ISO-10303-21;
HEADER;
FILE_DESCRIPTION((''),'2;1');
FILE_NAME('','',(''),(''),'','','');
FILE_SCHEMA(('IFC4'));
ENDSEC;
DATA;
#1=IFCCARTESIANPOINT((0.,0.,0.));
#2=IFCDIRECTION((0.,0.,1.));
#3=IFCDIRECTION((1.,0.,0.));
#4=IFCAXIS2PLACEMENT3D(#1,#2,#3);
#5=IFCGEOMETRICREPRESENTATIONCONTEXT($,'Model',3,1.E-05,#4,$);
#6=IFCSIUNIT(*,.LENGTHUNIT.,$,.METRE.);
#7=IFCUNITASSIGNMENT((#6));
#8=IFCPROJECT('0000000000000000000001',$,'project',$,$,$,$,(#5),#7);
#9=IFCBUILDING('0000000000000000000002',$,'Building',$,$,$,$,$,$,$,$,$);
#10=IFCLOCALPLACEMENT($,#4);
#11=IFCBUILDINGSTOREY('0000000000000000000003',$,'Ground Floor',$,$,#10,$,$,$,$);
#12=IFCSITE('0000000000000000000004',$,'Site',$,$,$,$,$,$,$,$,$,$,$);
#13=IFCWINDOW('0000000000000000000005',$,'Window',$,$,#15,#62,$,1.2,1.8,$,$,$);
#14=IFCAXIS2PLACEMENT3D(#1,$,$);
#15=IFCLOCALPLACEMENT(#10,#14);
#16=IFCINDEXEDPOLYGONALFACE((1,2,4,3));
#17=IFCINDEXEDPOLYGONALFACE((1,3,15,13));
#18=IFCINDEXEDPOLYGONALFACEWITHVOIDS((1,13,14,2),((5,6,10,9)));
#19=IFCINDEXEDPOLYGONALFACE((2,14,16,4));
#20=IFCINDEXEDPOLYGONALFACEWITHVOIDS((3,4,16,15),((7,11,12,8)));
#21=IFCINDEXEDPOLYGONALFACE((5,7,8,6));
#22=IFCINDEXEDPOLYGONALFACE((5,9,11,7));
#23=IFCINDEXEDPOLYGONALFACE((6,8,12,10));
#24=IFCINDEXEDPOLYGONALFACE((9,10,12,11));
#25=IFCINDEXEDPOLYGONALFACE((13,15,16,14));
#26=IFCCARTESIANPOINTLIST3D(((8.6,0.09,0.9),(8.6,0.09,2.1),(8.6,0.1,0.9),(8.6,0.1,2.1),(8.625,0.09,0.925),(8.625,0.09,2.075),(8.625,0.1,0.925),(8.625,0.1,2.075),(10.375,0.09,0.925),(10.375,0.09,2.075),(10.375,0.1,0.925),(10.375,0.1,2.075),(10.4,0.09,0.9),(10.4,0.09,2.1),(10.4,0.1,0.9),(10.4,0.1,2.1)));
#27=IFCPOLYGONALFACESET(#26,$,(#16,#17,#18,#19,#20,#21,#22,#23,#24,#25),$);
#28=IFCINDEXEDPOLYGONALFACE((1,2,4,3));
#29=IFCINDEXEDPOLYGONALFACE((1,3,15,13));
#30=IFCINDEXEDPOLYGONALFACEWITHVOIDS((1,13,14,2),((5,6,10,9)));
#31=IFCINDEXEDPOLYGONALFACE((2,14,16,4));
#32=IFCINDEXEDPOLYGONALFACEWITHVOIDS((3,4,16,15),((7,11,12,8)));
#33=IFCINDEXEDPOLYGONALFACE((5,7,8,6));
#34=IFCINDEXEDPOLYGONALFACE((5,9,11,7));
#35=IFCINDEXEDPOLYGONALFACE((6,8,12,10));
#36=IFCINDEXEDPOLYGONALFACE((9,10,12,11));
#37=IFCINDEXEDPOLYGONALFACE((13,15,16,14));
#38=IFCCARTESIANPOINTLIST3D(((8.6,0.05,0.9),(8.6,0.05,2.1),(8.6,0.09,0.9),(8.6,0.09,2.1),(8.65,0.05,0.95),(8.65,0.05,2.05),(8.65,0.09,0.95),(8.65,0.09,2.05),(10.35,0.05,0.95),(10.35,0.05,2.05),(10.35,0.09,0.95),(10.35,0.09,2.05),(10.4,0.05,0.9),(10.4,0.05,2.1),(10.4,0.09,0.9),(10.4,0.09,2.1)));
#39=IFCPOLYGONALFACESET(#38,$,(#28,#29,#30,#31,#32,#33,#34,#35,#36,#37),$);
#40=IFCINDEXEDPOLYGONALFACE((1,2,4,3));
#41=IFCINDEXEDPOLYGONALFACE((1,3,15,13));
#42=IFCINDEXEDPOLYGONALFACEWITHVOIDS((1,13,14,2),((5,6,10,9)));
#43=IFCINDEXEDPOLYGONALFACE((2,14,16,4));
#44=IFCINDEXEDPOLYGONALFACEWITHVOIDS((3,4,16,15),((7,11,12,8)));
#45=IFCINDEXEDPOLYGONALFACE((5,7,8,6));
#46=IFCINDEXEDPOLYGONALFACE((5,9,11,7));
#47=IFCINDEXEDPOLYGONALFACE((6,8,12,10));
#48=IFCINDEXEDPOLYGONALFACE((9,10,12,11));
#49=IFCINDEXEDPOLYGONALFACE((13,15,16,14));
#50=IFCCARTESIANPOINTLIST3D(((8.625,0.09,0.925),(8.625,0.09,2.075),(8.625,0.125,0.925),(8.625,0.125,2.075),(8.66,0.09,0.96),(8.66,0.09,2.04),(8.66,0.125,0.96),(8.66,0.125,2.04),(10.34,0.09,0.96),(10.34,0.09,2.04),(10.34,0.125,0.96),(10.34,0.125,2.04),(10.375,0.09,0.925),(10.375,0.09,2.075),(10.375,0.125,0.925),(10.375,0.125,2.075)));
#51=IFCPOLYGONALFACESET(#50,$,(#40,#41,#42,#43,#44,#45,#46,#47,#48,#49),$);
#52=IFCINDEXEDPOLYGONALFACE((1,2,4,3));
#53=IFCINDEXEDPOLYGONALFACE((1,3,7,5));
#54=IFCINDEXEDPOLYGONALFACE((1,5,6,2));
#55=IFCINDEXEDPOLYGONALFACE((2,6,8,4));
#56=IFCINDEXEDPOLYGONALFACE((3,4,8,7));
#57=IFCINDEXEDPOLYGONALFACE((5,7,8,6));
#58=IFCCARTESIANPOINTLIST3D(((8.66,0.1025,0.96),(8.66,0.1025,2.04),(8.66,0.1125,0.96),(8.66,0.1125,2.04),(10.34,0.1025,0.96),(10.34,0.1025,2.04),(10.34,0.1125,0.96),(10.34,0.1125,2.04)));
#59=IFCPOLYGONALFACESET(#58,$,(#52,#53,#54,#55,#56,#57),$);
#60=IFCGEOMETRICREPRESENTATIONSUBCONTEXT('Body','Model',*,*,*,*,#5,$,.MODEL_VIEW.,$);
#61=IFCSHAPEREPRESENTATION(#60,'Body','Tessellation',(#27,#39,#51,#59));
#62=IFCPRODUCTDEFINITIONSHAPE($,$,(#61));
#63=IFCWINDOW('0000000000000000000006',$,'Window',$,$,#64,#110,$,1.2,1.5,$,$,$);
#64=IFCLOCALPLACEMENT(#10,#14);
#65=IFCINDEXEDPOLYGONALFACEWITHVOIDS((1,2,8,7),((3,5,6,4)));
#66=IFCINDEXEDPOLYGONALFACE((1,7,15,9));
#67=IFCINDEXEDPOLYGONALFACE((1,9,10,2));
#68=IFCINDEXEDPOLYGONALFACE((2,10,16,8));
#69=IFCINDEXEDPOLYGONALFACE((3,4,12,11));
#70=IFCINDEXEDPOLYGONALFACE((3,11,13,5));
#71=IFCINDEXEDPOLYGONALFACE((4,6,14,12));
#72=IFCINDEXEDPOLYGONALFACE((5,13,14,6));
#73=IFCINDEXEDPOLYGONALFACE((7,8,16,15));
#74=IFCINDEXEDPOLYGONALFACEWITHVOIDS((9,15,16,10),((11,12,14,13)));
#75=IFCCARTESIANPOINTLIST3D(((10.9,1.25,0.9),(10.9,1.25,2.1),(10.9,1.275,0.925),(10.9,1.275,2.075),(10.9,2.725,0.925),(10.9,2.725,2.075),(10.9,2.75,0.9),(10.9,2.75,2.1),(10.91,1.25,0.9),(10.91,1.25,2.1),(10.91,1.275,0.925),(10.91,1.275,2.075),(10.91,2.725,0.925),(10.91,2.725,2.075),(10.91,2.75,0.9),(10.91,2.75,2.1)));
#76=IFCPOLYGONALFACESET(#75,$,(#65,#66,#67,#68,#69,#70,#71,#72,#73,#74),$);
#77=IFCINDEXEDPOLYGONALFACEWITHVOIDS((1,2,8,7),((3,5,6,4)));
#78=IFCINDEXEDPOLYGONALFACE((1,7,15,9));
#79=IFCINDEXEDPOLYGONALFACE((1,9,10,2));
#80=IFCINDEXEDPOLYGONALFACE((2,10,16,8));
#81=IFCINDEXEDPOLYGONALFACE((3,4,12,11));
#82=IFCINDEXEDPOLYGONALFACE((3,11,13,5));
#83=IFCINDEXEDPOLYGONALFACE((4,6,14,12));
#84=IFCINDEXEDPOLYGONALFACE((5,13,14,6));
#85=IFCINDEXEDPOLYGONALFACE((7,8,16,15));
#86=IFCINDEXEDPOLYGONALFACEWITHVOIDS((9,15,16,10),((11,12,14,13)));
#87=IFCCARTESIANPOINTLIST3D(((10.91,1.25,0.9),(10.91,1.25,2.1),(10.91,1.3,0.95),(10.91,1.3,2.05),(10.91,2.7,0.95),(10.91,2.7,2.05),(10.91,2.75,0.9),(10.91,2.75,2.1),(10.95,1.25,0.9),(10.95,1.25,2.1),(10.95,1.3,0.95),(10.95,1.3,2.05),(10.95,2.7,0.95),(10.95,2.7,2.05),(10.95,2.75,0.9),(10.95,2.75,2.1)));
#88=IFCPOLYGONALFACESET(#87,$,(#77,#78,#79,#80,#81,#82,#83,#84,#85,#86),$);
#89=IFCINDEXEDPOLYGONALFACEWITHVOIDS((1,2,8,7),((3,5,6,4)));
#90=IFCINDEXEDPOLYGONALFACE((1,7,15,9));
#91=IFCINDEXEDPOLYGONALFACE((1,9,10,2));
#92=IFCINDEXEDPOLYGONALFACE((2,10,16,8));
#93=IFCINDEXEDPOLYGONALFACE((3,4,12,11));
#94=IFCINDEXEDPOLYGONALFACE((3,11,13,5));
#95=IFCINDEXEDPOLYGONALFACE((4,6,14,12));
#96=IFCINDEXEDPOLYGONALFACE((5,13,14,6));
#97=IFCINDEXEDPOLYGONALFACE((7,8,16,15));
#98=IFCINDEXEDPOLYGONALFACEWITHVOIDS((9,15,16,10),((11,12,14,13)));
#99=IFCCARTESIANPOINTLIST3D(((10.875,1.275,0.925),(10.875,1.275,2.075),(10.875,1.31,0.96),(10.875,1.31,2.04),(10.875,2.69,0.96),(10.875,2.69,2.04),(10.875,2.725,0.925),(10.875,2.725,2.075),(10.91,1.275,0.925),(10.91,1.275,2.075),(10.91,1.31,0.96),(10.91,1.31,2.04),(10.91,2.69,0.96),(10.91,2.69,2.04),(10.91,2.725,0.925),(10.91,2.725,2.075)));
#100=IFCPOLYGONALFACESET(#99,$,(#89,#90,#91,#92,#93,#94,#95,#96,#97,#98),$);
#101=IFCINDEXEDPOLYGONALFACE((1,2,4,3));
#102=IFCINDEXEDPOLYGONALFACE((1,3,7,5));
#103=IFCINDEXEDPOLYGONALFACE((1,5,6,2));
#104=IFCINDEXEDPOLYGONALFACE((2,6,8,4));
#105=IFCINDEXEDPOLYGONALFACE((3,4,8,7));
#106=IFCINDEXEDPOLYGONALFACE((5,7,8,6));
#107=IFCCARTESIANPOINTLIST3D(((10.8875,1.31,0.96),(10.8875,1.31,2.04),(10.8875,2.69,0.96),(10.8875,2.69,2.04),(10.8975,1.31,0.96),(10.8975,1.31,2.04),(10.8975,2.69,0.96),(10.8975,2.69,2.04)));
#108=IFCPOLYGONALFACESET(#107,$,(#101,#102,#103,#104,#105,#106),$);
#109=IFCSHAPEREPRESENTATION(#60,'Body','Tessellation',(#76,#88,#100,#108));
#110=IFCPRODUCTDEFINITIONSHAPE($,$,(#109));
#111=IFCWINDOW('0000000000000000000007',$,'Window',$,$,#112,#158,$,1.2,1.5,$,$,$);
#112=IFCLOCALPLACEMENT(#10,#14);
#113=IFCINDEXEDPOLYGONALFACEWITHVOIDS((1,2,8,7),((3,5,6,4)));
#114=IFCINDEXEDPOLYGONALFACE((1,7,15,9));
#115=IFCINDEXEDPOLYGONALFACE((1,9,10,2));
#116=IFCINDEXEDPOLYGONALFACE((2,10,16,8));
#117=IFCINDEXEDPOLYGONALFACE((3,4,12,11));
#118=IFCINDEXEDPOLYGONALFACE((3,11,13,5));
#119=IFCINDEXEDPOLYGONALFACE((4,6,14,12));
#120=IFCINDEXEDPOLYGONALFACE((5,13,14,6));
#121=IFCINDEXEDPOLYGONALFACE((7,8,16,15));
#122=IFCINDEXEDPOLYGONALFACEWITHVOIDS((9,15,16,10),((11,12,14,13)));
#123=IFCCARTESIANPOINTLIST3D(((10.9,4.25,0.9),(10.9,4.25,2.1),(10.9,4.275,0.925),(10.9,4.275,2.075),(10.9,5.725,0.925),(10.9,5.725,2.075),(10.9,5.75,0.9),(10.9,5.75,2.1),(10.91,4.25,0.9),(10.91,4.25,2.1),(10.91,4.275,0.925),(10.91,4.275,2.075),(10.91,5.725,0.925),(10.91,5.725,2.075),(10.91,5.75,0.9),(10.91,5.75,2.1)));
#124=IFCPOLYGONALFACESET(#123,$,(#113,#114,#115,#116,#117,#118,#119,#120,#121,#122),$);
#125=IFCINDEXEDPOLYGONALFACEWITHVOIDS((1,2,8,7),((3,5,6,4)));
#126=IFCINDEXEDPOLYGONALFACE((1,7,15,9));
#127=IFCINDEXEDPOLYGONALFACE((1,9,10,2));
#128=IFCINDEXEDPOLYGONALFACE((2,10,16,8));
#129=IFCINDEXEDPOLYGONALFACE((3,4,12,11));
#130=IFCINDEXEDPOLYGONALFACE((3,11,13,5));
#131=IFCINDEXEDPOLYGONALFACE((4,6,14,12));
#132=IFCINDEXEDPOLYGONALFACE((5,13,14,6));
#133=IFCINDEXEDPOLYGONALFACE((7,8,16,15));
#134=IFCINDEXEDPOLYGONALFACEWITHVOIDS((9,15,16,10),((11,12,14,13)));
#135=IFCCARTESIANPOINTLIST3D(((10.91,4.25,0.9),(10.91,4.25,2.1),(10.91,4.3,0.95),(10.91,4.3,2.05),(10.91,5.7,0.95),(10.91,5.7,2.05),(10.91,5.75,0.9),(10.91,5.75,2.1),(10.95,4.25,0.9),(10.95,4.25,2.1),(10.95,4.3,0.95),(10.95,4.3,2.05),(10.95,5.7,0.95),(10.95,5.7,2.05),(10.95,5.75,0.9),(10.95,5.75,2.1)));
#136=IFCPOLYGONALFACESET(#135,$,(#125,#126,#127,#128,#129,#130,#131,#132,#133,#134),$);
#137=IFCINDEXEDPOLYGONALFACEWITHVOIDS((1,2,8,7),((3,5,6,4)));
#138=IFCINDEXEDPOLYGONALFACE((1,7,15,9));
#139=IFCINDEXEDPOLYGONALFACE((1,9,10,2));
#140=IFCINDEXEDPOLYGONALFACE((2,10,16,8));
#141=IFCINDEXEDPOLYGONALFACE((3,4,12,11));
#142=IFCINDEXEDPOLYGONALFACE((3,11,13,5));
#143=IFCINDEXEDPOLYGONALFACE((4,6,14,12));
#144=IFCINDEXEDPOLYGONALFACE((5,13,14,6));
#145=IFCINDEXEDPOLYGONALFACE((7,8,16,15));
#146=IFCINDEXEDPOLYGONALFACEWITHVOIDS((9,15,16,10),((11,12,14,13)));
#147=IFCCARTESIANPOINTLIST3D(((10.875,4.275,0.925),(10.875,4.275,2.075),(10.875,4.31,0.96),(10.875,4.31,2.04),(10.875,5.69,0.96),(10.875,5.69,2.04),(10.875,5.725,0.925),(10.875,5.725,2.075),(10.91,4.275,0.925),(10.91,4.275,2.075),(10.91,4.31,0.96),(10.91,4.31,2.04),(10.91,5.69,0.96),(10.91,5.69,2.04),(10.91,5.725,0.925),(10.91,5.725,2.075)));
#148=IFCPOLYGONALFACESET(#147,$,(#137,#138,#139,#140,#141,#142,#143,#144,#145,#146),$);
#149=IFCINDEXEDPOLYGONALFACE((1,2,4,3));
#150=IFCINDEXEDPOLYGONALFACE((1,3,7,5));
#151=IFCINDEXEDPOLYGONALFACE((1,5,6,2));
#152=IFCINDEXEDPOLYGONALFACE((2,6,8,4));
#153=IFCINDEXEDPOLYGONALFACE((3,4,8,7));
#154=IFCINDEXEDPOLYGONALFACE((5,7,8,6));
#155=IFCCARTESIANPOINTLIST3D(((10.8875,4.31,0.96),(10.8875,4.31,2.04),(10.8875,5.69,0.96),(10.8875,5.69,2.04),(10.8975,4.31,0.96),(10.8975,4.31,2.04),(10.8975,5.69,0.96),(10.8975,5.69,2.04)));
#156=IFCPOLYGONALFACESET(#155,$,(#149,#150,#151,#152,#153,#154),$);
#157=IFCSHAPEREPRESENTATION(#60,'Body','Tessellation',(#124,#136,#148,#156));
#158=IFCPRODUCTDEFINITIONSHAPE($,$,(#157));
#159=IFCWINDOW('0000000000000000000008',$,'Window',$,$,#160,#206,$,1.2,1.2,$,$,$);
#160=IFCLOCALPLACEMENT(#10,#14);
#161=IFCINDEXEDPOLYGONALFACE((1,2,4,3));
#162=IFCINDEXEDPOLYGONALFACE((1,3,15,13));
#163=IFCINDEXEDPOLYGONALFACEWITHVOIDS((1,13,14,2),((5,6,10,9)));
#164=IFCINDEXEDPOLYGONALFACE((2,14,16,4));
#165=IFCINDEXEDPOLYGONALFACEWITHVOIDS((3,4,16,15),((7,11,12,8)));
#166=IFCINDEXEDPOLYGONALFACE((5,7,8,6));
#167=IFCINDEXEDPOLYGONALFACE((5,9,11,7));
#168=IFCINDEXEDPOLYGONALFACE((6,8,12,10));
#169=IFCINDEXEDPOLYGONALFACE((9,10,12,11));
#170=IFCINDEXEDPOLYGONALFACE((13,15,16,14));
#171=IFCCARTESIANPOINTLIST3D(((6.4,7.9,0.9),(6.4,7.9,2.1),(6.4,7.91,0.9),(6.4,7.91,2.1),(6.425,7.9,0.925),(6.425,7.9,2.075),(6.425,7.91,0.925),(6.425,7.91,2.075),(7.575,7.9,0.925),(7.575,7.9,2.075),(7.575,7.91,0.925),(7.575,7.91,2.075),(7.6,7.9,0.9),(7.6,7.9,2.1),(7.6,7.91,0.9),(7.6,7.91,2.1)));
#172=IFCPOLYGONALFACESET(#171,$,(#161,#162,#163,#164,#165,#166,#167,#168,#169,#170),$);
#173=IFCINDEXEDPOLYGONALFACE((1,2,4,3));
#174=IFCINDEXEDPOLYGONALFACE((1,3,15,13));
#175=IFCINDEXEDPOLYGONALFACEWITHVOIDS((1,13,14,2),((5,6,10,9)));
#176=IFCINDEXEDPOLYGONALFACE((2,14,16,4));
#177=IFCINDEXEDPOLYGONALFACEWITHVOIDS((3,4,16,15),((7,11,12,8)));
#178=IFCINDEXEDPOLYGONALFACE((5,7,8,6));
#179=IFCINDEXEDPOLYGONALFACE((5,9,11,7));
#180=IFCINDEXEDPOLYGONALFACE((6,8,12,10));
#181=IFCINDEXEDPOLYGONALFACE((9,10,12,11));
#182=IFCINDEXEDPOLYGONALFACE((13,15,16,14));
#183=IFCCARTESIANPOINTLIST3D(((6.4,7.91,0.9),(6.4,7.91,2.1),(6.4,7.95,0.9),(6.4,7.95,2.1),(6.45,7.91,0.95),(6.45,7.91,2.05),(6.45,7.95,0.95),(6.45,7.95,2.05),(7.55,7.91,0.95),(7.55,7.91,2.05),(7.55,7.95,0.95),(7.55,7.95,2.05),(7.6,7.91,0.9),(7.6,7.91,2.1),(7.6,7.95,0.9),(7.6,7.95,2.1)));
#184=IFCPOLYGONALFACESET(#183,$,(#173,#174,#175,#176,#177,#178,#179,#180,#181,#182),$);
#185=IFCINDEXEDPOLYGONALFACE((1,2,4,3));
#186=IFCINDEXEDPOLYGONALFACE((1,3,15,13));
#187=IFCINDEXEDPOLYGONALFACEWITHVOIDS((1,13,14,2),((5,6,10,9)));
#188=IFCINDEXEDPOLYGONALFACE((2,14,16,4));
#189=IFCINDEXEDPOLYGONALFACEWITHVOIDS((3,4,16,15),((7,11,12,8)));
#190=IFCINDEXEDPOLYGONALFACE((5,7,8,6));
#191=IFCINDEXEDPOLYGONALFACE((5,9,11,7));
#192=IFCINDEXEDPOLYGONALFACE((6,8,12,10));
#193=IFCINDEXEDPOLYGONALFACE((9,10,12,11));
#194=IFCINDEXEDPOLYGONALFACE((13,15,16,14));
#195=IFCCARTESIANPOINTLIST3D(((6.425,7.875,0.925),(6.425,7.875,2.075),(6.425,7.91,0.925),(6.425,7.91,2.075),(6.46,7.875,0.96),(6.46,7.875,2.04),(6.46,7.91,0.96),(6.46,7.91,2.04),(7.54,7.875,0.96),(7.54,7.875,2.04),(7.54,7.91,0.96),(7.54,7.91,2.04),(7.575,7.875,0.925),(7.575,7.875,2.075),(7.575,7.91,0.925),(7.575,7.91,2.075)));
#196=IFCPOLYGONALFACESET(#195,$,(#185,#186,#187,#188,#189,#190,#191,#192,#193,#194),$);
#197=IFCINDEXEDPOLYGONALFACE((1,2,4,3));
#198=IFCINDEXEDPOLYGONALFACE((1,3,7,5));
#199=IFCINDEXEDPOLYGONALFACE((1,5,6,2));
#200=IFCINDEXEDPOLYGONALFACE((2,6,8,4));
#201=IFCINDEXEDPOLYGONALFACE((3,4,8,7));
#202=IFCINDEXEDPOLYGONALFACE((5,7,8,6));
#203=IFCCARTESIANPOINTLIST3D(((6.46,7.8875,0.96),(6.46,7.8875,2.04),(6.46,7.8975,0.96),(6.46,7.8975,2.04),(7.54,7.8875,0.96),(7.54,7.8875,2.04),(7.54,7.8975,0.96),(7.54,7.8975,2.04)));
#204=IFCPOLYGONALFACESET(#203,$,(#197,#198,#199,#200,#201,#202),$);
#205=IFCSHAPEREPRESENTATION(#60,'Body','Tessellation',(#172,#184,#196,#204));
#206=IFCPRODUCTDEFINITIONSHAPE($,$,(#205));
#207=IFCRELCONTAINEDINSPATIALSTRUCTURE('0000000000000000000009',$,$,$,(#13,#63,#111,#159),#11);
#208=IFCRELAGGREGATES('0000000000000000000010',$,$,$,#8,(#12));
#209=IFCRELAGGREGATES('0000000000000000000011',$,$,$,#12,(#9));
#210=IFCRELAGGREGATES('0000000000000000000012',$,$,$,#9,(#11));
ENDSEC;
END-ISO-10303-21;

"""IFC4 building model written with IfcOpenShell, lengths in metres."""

from ifc_helpers import new_model, si_unit, frame, origin_with_axes, place, context, subcontext, project, spatial, line, indexed_curve, outline, extrude, element, save


model = new_model("IFC4")

# Units and contexts
model_context = context("Model", 3, precision=1e-05, world=origin_with_axes())
body_context = subcontext(model_context, "Body", "Model", "MODEL_VIEW")
ifc_project = project(units=[si_unit("LENGTHUNIT", "METRE")], contexts=[model_context])

# Site, building, storey
site = spatial("IfcSite", under=ifc_project, Name="Site")
building = spatial("IfcBuilding", under=site, Name="Building")
storey_placement = place(None, origin_with_axes())
storey = spatial("IfcBuildingStorey", under=building, at=storey_placement, Name="Ground Floor")

# Windows
window_1_placement = place(storey_placement, frame((8.6, 0.0, 0.9), z_axis=(0.0, 0.0, 1.0), x_axis=(1.0, 0.0, 0.0)))
element("IfcWindow", 1, at=window_1_placement, inside=storey, Name="Window", OverallHeight=1.2, OverallWidth=1.8, context=body_context, shape_type="SweptSolid", body=[
    extrude(outline(indexed_curve([(0.0, 0.0), (1.8, 0.0), (1.8, 1.2), (0.0, 1.2)], segments=[line(1, 2, 3, 4, 1)]), holes=[indexed_curve([(0.025, 0.025), (1.775, 0.025), (1.775, 1.175), (0.025, 1.175)], segments=[line(1, 2, 3, 4, 1)])]), frame((0.0, 0.09, 0.0), z_axis=(0.0, -1.0, 0.0), x_axis=(1.0, 0.0, 0.0)), (0.0, 0.0, -1.0), 0.01),
    extrude(outline(indexed_curve([(0.0, 0.0), (1.8, 0.0), (1.8, 1.2), (0.0, 1.2)], segments=[line(1, 2, 3, 4, 1)]), holes=[indexed_curve([(0.05, 0.05), (1.75, 0.05), (1.75, 1.15), (0.05, 1.15)], segments=[line(1, 2, 3, 4, 1)])]), frame((0.0, 0.05, 0.0), z_axis=(0.0, -1.0, 0.0), x_axis=(1.0, 0.0, 0.0)), (0.0, 0.0, -1.0), 0.04),
    extrude(outline(indexed_curve([(0.0, 0.0), (1.75, 0.0), (1.75, 1.15), (0.0, 1.15)], segments=[line(1, 2, 3, 4, 1)]), holes=[indexed_curve([(0.035, 0.035), (1.715, 0.035), (1.715, 1.115), (0.035, 1.115)], segments=[line(1, 2, 3, 4, 1)])]), frame((0.025, 0.09, 0.025), z_axis=(0.0, -1.0, 0.0), x_axis=(1.0, 0.0, 0.0)), (0.0, 0.0, -1.0), 0.035),
    extrude(outline(indexed_curve([(0.035, 0.035), (1.715, 0.035), (1.715, 1.115), (0.035, 1.115)], segments=[line(1, 2, 3, 4, 1)])), frame((0.025, 0.1025, 0.025), z_axis=(0.0, -1.0, 0.0), x_axis=(1.0, 0.0, 0.0)), (0.0, 0.0, -1.0), 0.01),
])
for number, where, z_axis, x_axis, name in (
    (2, (11.0, 1.25, 0.9), (0.0, 0.0, 1.0), (0.0, 1.0, 0.0), "Window"),
    (3, (11.0, 4.25, 0.9), (0.0, 0.0, 1.0), (0.0, 1.0, 0.0), "Window"),
):
    element("IfcWindow", number, at=place(storey_placement, frame(where, z_axis=z_axis, x_axis=x_axis)), inside=storey, Name=name, OverallHeight=1.2, OverallWidth=1.5, context=body_context, shape_type="SweptSolid", body=[
        extrude(outline(indexed_curve([(0.0, 0.0), (1.5, 0.0), (1.5, 1.2), (0.0, 1.2)], segments=[line(1, 2, 3, 4, 1)]), holes=[indexed_curve([(0.025, 0.025), (1.475, 0.025), (1.475, 1.175), (0.025, 1.175)], segments=[line(1, 2, 3, 4, 1)])]), frame((0.0, 0.09, 0.0), z_axis=(0.0, -1.0, 0.0), x_axis=(1.0, 0.0, 0.0)), (0.0, 0.0, -1.0), 0.01),
        extrude(outline(indexed_curve([(0.0, 0.0), (1.5, 0.0), (1.5, 1.2), (0.0, 1.2)], segments=[line(1, 2, 3, 4, 1)]), holes=[indexed_curve([(0.05, 0.05), (1.45, 0.05), (1.45, 1.15), (0.05, 1.15)], segments=[line(1, 2, 3, 4, 1)])]), frame((0.0, 0.05, 0.0), z_axis=(0.0, -1.0, 0.0), x_axis=(1.0, 0.0, 0.0)), (0.0, 0.0, -1.0), 0.04),
        extrude(outline(indexed_curve([(0.0, 0.0), (1.45, 0.0), (1.45, 1.15), (0.0, 1.15)], segments=[line(1, 2, 3, 4, 1)]), holes=[indexed_curve([(0.035, 0.035), (1.415, 0.035), (1.415, 1.115), (0.035, 1.115)], segments=[line(1, 2, 3, 4, 1)])]), frame((0.025, 0.09, 0.025), z_axis=(0.0, -1.0, 0.0), x_axis=(1.0, 0.0, 0.0)), (0.0, 0.0, -1.0), 0.035),
        extrude(outline(indexed_curve([(0.035, 0.035), (1.415, 0.035), (1.415, 1.115), (0.035, 1.115)], segments=[line(1, 2, 3, 4, 1)])), frame((0.025, 0.1025, 0.025), z_axis=(0.0, -1.0, 0.0), x_axis=(1.0, 0.0, 0.0)), (0.0, 0.0, -1.0), 0.01),
    ])
window_2_placement = place(storey_placement, frame((7.6, 8.0, 0.9), z_axis=(0.0, 0.0, 1.0), x_axis=(-1.0, 0.0, 0.0)))
element("IfcWindow", 4, at=window_2_placement, inside=storey, Name="Window", OverallHeight=1.2, OverallWidth=1.2, context=body_context, shape_type="SweptSolid", body=[
    extrude(outline(indexed_curve([(0.0, 0.0), (1.2, 0.0), (1.2, 1.2), (0.0, 1.2)], segments=[line(1, 2, 3, 4, 1)]), holes=[indexed_curve([(0.025, 0.025), (1.175, 0.025), (1.175, 1.175), (0.025, 1.175)], segments=[line(1, 2, 3, 4, 1)])]), frame((0.0, 0.09, 0.0), z_axis=(0.0, -1.0, 0.0), x_axis=(1.0, 0.0, 0.0)), (0.0, 0.0, -1.0), 0.01),
    extrude(outline(indexed_curve([(0.0, 0.0), (1.2, 0.0), (1.2, 1.2), (0.0, 1.2)], segments=[line(1, 2, 3, 4, 1)]), holes=[indexed_curve([(0.05, 0.05), (1.15, 0.05), (1.15, 1.15), (0.05, 1.15)], segments=[line(1, 2, 3, 4, 1)])]), frame((0.0, 0.05, 0.0), z_axis=(0.0, -1.0, 0.0), x_axis=(1.0, 0.0, 0.0)), (0.0, 0.0, -1.0), 0.04),
    extrude(outline(indexed_curve([(0.0, 0.0), (1.15, 0.0), (1.15, 1.15), (0.0, 1.15)], segments=[line(1, 2, 3, 4, 1)]), holes=[indexed_curve([(0.035, 0.035), (1.115, 0.035), (1.115, 1.115), (0.035, 1.115)], segments=[line(1, 2, 3, 4, 1)])]), frame((0.025, 0.09, 0.025), z_axis=(0.0, -1.0, 0.0), x_axis=(1.0, 0.0, 0.0)), (0.0, 0.0, -1.0), 0.035),
    extrude(outline(indexed_curve([(0.035, 0.035), (1.115, 0.035), (1.115, 1.115), (0.035, 1.115)], segments=[line(1, 2, 3, 4, 1)])), frame((0.025, 0.1025, 0.025), z_axis=(0.0, -1.0, 0.0), x_axis=(1.0, 0.0, 0.0)), (0.0, 0.0, -1.0), 0.01),
])

save(model, "model.ifc")
